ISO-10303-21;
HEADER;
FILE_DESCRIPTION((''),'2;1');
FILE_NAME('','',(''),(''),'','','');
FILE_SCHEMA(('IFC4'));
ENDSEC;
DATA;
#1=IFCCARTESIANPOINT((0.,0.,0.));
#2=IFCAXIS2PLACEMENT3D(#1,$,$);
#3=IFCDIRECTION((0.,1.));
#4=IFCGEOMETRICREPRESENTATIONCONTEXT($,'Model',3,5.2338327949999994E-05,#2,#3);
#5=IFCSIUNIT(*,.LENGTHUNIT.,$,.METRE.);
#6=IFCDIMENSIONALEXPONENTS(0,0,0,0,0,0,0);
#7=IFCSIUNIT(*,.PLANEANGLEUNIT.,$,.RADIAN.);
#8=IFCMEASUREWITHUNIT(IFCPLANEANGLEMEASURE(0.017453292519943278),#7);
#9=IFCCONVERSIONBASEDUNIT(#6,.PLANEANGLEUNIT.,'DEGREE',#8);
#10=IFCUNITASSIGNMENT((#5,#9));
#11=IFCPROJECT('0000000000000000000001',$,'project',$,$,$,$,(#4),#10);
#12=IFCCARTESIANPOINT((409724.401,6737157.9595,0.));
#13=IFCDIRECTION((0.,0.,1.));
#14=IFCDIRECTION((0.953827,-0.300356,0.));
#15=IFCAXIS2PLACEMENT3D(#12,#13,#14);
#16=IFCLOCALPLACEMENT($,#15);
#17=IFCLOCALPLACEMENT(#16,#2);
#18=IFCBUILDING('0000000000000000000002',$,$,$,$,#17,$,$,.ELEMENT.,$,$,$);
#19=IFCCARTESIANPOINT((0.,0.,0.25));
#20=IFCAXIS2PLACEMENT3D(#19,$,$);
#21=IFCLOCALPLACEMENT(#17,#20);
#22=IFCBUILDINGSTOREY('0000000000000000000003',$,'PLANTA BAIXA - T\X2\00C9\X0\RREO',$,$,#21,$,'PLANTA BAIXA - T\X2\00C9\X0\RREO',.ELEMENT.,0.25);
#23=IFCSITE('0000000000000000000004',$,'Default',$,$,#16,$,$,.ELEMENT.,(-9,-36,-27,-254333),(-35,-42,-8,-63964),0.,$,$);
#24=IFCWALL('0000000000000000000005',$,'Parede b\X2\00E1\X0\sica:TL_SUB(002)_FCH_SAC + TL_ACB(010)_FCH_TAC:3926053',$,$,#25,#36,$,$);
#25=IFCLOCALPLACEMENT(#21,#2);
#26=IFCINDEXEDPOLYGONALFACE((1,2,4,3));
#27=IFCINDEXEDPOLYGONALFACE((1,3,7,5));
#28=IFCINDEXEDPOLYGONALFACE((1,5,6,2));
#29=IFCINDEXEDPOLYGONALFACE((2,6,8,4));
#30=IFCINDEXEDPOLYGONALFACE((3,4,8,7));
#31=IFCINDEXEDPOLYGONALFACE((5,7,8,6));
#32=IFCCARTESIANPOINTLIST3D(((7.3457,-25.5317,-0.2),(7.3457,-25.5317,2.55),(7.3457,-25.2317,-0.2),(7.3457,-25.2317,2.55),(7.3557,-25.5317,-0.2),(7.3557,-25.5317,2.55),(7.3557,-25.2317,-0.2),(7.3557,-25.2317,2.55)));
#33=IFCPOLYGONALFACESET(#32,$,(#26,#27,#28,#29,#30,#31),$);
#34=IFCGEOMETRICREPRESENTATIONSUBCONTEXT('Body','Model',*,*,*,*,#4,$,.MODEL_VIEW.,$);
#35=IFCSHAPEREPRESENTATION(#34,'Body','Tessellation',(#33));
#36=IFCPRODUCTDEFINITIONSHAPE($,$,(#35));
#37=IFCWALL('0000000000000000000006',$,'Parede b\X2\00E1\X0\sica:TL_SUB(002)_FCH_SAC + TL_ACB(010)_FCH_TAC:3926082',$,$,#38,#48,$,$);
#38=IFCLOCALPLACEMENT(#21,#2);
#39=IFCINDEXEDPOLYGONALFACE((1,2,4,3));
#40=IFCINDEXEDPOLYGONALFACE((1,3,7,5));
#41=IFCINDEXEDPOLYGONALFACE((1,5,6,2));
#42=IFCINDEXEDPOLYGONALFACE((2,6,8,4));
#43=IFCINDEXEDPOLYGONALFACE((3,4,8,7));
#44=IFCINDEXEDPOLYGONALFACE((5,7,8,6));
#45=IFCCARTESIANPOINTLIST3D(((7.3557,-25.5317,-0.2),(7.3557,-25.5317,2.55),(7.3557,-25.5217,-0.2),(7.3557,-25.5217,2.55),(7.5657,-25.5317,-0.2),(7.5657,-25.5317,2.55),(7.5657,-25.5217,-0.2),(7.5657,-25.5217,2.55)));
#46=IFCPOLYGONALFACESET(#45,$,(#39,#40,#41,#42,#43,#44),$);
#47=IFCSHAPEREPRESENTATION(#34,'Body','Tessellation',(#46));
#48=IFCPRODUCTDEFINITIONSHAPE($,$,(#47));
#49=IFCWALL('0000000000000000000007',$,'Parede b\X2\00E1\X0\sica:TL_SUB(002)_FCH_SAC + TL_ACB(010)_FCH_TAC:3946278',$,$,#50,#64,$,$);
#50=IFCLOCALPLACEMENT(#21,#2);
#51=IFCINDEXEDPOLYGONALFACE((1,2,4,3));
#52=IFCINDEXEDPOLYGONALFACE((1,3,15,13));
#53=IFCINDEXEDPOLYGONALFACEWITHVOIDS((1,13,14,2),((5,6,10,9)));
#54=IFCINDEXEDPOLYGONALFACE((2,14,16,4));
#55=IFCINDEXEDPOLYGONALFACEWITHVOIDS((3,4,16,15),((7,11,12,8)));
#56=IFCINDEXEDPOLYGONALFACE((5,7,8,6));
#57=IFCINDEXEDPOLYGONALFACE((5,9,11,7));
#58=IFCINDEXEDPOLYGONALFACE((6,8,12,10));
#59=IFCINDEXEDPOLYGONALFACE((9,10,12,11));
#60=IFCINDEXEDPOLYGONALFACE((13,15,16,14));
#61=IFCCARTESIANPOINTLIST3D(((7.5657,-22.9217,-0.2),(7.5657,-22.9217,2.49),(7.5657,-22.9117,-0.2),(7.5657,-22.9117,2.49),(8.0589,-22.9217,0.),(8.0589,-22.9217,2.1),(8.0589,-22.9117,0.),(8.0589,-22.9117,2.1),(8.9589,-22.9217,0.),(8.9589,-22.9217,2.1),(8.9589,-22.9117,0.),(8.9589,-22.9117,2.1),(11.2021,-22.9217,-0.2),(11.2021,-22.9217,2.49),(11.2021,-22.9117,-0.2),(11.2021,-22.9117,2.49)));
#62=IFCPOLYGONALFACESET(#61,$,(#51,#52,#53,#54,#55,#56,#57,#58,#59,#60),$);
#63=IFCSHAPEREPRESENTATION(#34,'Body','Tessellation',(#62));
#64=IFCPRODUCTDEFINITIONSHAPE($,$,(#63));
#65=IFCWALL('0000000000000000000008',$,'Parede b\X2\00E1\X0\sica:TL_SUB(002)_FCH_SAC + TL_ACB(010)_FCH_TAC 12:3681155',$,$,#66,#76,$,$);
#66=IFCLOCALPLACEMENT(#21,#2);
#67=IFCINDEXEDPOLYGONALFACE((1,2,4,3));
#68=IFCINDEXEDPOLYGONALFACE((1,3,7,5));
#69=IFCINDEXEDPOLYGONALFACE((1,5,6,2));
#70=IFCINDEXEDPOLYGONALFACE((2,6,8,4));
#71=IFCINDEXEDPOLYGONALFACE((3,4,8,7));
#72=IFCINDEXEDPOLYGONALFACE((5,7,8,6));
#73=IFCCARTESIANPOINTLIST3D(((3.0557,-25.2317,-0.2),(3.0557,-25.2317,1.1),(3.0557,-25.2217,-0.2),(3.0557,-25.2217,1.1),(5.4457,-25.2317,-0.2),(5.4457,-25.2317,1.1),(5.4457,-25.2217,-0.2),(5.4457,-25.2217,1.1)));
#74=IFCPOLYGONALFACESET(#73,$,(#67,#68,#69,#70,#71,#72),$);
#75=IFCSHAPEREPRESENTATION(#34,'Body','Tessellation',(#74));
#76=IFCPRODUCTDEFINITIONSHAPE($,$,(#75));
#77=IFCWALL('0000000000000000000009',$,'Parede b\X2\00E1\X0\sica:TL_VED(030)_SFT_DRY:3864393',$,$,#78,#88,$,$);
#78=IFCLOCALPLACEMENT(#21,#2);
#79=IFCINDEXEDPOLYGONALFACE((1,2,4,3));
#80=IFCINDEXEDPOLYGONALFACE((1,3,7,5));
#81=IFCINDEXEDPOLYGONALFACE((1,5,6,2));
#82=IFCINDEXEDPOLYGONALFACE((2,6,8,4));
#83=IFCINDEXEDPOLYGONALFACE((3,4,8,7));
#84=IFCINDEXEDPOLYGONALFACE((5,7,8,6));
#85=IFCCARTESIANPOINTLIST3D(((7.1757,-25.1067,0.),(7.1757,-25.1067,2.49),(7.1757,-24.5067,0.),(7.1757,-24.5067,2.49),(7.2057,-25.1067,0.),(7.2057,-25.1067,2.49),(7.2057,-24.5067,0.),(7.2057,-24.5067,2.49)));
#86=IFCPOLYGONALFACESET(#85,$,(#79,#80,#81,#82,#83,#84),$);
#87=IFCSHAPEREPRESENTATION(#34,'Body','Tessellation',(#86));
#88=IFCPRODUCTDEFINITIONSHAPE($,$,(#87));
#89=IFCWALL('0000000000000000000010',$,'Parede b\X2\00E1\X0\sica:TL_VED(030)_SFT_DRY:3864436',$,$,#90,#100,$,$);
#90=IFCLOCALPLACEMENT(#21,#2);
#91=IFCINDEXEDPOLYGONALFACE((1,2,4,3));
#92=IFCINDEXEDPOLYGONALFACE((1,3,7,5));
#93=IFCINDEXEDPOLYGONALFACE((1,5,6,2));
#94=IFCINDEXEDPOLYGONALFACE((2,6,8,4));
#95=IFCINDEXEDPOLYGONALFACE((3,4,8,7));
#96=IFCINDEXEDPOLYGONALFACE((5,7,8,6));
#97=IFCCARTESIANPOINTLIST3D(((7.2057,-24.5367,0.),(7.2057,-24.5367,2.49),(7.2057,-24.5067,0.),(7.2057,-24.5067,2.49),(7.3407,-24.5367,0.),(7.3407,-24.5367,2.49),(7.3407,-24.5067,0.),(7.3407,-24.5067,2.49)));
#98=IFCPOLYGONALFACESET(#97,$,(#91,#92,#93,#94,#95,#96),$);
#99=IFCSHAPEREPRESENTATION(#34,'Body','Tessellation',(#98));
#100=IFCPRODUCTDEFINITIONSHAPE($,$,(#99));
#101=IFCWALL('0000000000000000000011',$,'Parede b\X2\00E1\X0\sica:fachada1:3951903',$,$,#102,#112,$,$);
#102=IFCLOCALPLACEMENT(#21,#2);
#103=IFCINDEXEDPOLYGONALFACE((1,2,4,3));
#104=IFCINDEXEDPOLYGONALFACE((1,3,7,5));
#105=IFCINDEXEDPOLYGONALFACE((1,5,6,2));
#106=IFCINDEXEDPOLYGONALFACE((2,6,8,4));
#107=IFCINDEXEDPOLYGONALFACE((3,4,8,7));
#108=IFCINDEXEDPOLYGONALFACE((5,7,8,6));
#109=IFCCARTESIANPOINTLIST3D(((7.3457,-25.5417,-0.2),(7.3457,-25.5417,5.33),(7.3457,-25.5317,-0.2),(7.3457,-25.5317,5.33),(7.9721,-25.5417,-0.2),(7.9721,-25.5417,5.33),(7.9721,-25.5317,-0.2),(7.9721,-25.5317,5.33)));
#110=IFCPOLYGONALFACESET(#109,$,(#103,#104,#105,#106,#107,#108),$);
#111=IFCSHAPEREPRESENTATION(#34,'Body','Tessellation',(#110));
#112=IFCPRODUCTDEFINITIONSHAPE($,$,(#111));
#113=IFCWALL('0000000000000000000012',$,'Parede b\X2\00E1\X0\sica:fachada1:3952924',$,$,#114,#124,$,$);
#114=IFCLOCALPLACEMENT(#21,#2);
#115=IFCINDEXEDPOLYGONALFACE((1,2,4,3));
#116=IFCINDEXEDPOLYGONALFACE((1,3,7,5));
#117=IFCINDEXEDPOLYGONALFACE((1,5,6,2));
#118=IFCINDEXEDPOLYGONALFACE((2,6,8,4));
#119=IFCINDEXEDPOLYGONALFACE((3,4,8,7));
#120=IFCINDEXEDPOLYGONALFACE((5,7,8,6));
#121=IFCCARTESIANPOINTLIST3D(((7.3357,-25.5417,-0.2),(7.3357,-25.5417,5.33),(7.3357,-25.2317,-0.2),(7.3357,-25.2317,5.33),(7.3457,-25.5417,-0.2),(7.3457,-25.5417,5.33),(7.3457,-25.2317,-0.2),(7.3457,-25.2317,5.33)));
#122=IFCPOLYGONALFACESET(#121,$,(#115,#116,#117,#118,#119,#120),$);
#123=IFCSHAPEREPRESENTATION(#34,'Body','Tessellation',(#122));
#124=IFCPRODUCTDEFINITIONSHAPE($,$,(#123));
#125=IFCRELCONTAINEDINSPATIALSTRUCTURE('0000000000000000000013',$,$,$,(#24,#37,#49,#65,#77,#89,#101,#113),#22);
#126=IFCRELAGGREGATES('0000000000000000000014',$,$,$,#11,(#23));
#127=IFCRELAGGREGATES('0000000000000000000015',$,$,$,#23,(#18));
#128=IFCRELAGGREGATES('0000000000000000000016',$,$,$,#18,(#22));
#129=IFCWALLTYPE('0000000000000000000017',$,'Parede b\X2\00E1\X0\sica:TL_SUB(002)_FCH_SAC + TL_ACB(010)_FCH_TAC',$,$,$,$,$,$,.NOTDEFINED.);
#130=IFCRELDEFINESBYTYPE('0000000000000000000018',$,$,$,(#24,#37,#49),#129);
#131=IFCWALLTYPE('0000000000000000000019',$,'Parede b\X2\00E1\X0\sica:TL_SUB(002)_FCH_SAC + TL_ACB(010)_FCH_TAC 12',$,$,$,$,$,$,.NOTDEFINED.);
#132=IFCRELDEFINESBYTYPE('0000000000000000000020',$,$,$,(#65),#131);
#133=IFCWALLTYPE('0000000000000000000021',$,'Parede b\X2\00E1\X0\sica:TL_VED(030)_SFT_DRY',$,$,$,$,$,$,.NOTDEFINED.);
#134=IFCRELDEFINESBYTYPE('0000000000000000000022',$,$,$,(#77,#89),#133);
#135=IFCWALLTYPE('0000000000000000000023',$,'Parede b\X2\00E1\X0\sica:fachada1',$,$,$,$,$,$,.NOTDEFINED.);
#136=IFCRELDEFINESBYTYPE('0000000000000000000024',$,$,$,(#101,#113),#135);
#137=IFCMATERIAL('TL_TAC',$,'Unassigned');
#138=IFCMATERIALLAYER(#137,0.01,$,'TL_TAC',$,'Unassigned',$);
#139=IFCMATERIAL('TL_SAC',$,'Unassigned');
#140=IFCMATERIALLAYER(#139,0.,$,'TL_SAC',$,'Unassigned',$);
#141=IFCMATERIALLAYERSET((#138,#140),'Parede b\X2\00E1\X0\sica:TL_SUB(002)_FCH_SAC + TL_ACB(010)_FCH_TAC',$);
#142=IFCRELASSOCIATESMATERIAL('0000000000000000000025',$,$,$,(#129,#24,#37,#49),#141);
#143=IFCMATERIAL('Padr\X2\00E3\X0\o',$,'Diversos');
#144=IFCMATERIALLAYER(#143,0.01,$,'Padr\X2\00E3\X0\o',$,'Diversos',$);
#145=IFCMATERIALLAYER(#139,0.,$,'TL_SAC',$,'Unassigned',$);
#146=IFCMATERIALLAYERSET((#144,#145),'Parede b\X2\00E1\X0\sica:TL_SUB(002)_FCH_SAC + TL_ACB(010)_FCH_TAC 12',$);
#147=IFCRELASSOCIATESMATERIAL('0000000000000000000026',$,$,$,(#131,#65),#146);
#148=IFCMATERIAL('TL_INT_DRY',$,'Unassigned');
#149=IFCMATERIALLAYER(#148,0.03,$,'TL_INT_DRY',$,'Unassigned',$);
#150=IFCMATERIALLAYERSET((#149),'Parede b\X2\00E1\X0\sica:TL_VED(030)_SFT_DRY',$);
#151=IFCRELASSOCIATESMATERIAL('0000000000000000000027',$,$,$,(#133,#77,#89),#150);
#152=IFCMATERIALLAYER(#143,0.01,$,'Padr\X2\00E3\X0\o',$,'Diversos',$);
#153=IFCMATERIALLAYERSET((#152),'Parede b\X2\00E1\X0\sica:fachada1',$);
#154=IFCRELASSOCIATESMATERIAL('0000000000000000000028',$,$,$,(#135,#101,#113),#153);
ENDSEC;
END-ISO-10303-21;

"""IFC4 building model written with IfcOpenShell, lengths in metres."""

from ifc_helpers import new_model, entity, si_unit, converted_unit, direction, frame, frame_2d, origin, place, context, subcontext, project, spatial, polyline, rectangle, extrude, clip, bounded_halfspace, material, layer, layer_set, layer_usage, type_object, element, save


model = new_model("IFC4")

# Units and contexts
model_context = context("Model", 3, precision=5.2338327949999994e-05, world=origin(), true_north=direction((0.0, 1.0)))
body_context = subcontext(model_context, "Body", "Model", "MODEL_VIEW")
ifc_project = project(units=[si_unit("LENGTHUNIT", "METRE"), converted_unit("PLANEANGLEUNIT", "DEGREE", entity("IfcPlaneAngleMeasure", 0.017453292519943278), si_unit("PLANEANGLEUNIT", "RADIAN"), dimensions=[0, 0, 0, 0, 0, 0, 0])], contexts=[model_context])

# Site, building, storey
site_placement = place(None, frame((409724.401, 6737157.9595, 0.0), z_axis=(0.0, 0.0, 1.0), x_axis=(0.953827, -0.300356, 0.0)))
site = spatial("IfcSite", under=ifc_project, at=site_placement, Name="Default", CompositionType="ELEMENT", RefLatitude=(-9, -36, -27, -254333), RefLongitude=(-35, -42, -8, -63964), RefElevation=0.0)
building_placement = place(site_placement, origin())
building = spatial("IfcBuilding", under=site, at=building_placement, CompositionType="ELEMENT")
storey_placement = place(building_placement, frame((0.0, 0.0, 0.25)))
storey = spatial("IfcBuildingStorey", under=building, at=storey_placement, Name="PLANTA BAIXA - TÉRREO", LongName="PLANTA BAIXA - TÉRREO", CompositionType="ELEMENT", Elevation=0.25)

# Shared definitions
ifc_material_1 = material(Name="TL_SAC", Category="Unassigned")

# Shared definitions
ifc_material_2 = material(Name="TL_TAC", Category="Unassigned")
ifc_layer_1 = layer(ifc_material_2, 0.01, Name="TL_TAC", Category="Unassigned")
ifc_layer_2 = layer(ifc_material_1, 0.0, Name="TL_SAC", Category="Unassigned")
ifc_layer_set_1 = layer_set([ifc_layer_1, ifc_layer_2], Name="Parede básica:TL_SUB(002)_FCH_SAC + TL_ACB(010)_FCH_TAC")
wall_type_1 = type_object("IfcWallType", Name="Parede básica:TL_SUB(002)_FCH_SAC + TL_ACB(010)_FCH_TAC", PredefinedType="NOTDEFINED", material=ifc_layer_set_1)

# Walls
ifc_layer_usage_1 = layer_usage(ifc_layer_set_1, "AXIS2", "NEGATIVE", 0.005)
wall_1_placement = place(storey_placement, frame((7.3507, -25.2317, -0.2), z_axis=(0.0, 0.0, 1.0), x_axis=(0.0, -1.0, 0.0)))
element("IfcWall", 1, at=wall_1_placement, inside=storey, type_object=wall_type_1, material=ifc_layer_usage_1, Name="Parede básica:TL_SUB(002)_FCH_SAC + TL_ACB(010)_FCH_TAC:3926053", context=body_context, shape_type="SweptSolid", body=[
    extrude(rectangle(XDim=0.3, YDim=0.01, at=frame_2d((0.15, 0.0), x_axis=(-1.0, 0.0))), origin(), (0.0, 0.0, 1.0), 2.75),
])
ifc_layer_usage_2 = layer_usage(ifc_layer_set_1, "AXIS2", "NEGATIVE", 0.005)
wall_2_placement = place(storey_placement, frame((7.3557, -25.5267, -0.2)))
element("IfcWall", 2, at=wall_2_placement, inside=storey, type_object=wall_type_1, material=ifc_layer_usage_2, Name="Parede básica:TL_SUB(002)_FCH_SAC + TL_ACB(010)_FCH_TAC:3926082", context=body_context, shape_type="SweptSolid", body=[
    extrude(rectangle(XDim=0.21, YDim=0.01, at=frame_2d((0.105, 0.0), x_axis=(-1.0, 0.0))), origin(), (0.0, 0.0, 1.0), 2.75),
])

# Wall, opening
ifc_layer_usage_3 = layer_usage(ifc_layer_set_1, "AXIS2", "POSITIVE", -0.005)
wall_3_placement = place(storey_placement, frame((7.5657, -22.9167, -0.2)))
wall_3 = element("IfcWall", 3, at=wall_3_placement, inside=storey, type_object=wall_type_1, material=ifc_layer_usage_3, Name="Parede básica:TL_SUB(002)_FCH_SAC + TL_ACB(010)_FCH_TAC:3946278", context=body_context, shape_type="Clipping", body=[
    clip(extrude(rectangle(XDim=3.6364, YDim=0.01, at=frame_2d((1.8182, 0.0), x_axis=(-1.0, 0.0))), origin(), (0.0, 0.0, 1.0), 2.69), bounded_halfspace(frame((0.0, -0.005, 2.69), z_axis=(0.0, 0.0, -1.0), x_axis=(0.0, -1.0, 0.0)), True, frame((0.0, -0.005, 2.69)), polyline([(0.0, 0.0), (3.6364, 0.0), (3.6364, 0.01), (0.0, 0.01), (0.0, 0.0)]))),
])
opening_1_placement = place(wall_3_placement, frame((-7.5657, 22.9167, 0.2)))
element("IfcOpeningElement", 4, at=opening_1_placement, cuts=wall_3, PredefinedType="OPENING", context=body_context, shape_type="SweptSolid", body=[
    extrude(rectangle(XDim=2.1, YDim=0.9, at=frame_2d((0.0, 0.0), x_axis=(1.0, 0.0))), frame((8.5089, -24.5957, 1.05), z_axis=(0.0, 1.0, 0.0), x_axis=(0.0, 0.0, 1.0)), (0.0, 0.0, 1.0), 3.048),
])

# Walls
ifc_material_3 = material(Name="Padrão", Category="Diversos")
ifc_layer_3 = layer(ifc_material_3, 0.01, Name="Padrão", Category="Diversos")
ifc_layer_4 = layer(ifc_material_1, 0.0, Name="TL_SAC", Category="Unassigned")
ifc_layer_set_2 = layer_set([ifc_layer_3, ifc_layer_4], Name="Parede básica:TL_SUB(002)_FCH_SAC + TL_ACB(010)_FCH_TAC 12")
ifc_layer_usage_4 = layer_usage(ifc_layer_set_2, "AXIS2", "POSITIVE", -0.005)
wall_type_2 = type_object("IfcWallType", Name="Parede básica:TL_SUB(002)_FCH_SAC + TL_ACB(010)_FCH_TAC 12", PredefinedType="NOTDEFINED", material=ifc_layer_set_2)
wall_4_placement = place(storey_placement, frame((5.4457, -25.2267, -0.2), z_axis=(0.0, 0.0, 1.0), x_axis=(-1.0, 0.0, 0.0)))
element("IfcWall", 5, at=wall_4_placement, inside=storey, type_object=wall_type_2, material=ifc_layer_usage_4, Name="Parede básica:TL_SUB(002)_FCH_SAC + TL_ACB(010)_FCH_TAC 12:3681155", context=body_context, shape_type="SweptSolid", body=[
    extrude(rectangle(XDim=2.39, YDim=0.01, at=frame_2d((1.195, 0.0), x_axis=(-1.0, 0.0))), origin(), (0.0, 0.0, 1.0), 1.3),
])
ifc_material_4 = material(Name="TL_INT_DRY", Category="Unassigned")
ifc_layer_5 = layer(ifc_material_4, 0.03, Name="TL_INT_DRY", Category="Unassigned")
ifc_layer_set_3 = layer_set([ifc_layer_5], Name="Parede básica:TL_VED(030)_SFT_DRY")
ifc_layer_usage_5 = layer_usage(ifc_layer_set_3, "AXIS2", "NEGATIVE", 0.015)
wall_type_3 = type_object("IfcWallType", Name="Parede básica:TL_VED(030)_SFT_DRY", PredefinedType="NOTDEFINED", material=ifc_layer_set_3)
wall_5_placement = place(storey_placement, frame((7.1907, -25.1067, 0.0), z_axis=(0.0, 0.0, 1.0), x_axis=(0.0, 1.0, 0.0)))
element("IfcWall", 6, at=wall_5_placement, inside=storey, type_object=wall_type_3, material=ifc_layer_usage_5, Name="Parede básica:TL_VED(030)_SFT_DRY:3864393", context=body_context, shape_type="SweptSolid", body=[
    extrude(rectangle(XDim=0.6, YDim=0.03, at=frame_2d((0.3, 0.0), x_axis=(-1.0, 0.0))), origin(), (0.0, 0.0, 1.0), 2.49),
])
ifc_layer_usage_6 = layer_usage(ifc_layer_set_3, "AXIS2", "NEGATIVE", 0.015)
wall_6_placement = place(storey_placement, frame((7.2057, -24.5217, 0.0)))
element("IfcWall", 7, at=wall_6_placement, inside=storey, type_object=wall_type_3, material=ifc_layer_usage_6, Name="Parede básica:TL_VED(030)_SFT_DRY:3864436", context=body_context, shape_type="SweptSolid", body=[
    extrude(rectangle(XDim=0.135, YDim=0.03, at=frame_2d((0.0675, 0.0), x_axis=(-1.0, 0.0))), origin(), (0.0, 0.0, 1.0), 2.49),
])
ifc_layer_6 = layer(ifc_material_3, 0.01, Name="Padrão", Category="Diversos")
ifc_layer_set_4 = layer_set([ifc_layer_6], Name="Parede básica:fachada1")
ifc_layer_usage_7 = layer_usage(ifc_layer_set_4, "AXIS2", "NEGATIVE", 0.005)
wall_type_4 = type_object("IfcWallType", Name="Parede básica:fachada1", PredefinedType="NOTDEFINED", material=ifc_layer_set_4)
wall_7_placement = place(storey_placement, frame((7.3457, -25.5367, -0.2)))
element("IfcWall", 8, at=wall_7_placement, inside=storey, type_object=wall_type_4, material=ifc_layer_usage_7, Name="Parede básica:fachada1:3951903", context=body_context, shape_type="SweptSolid", body=[
    extrude(rectangle(XDim=0.6264, YDim=0.01, at=frame_2d((0.3132, 0.0), x_axis=(-1.0, 0.0))), origin(), (0.0, 0.0, 1.0), 5.53),
])
ifc_layer_usage_8 = layer_usage(ifc_layer_set_4, "AXIS2", "NEGATIVE", 0.005)
wall_8_placement = place(storey_placement, frame((7.3407, -25.2317, -0.2), z_axis=(0.0, 0.0, 1.0), x_axis=(0.0, -1.0, 0.0)))
element("IfcWall", 9, at=wall_8_placement, inside=storey, type_object=wall_type_4, material=ifc_layer_usage_8, Name="Parede básica:fachada1:3952924", context=body_context, shape_type="SweptSolid", body=[
    extrude(rectangle(XDim=0.31, YDim=0.01, at=frame_2d((0.155, 0.0), x_axis=(-1.0, 0.0))), origin(), (0.0, 0.0, 1.0), 5.53),
])

save(model, "model.ifc")
